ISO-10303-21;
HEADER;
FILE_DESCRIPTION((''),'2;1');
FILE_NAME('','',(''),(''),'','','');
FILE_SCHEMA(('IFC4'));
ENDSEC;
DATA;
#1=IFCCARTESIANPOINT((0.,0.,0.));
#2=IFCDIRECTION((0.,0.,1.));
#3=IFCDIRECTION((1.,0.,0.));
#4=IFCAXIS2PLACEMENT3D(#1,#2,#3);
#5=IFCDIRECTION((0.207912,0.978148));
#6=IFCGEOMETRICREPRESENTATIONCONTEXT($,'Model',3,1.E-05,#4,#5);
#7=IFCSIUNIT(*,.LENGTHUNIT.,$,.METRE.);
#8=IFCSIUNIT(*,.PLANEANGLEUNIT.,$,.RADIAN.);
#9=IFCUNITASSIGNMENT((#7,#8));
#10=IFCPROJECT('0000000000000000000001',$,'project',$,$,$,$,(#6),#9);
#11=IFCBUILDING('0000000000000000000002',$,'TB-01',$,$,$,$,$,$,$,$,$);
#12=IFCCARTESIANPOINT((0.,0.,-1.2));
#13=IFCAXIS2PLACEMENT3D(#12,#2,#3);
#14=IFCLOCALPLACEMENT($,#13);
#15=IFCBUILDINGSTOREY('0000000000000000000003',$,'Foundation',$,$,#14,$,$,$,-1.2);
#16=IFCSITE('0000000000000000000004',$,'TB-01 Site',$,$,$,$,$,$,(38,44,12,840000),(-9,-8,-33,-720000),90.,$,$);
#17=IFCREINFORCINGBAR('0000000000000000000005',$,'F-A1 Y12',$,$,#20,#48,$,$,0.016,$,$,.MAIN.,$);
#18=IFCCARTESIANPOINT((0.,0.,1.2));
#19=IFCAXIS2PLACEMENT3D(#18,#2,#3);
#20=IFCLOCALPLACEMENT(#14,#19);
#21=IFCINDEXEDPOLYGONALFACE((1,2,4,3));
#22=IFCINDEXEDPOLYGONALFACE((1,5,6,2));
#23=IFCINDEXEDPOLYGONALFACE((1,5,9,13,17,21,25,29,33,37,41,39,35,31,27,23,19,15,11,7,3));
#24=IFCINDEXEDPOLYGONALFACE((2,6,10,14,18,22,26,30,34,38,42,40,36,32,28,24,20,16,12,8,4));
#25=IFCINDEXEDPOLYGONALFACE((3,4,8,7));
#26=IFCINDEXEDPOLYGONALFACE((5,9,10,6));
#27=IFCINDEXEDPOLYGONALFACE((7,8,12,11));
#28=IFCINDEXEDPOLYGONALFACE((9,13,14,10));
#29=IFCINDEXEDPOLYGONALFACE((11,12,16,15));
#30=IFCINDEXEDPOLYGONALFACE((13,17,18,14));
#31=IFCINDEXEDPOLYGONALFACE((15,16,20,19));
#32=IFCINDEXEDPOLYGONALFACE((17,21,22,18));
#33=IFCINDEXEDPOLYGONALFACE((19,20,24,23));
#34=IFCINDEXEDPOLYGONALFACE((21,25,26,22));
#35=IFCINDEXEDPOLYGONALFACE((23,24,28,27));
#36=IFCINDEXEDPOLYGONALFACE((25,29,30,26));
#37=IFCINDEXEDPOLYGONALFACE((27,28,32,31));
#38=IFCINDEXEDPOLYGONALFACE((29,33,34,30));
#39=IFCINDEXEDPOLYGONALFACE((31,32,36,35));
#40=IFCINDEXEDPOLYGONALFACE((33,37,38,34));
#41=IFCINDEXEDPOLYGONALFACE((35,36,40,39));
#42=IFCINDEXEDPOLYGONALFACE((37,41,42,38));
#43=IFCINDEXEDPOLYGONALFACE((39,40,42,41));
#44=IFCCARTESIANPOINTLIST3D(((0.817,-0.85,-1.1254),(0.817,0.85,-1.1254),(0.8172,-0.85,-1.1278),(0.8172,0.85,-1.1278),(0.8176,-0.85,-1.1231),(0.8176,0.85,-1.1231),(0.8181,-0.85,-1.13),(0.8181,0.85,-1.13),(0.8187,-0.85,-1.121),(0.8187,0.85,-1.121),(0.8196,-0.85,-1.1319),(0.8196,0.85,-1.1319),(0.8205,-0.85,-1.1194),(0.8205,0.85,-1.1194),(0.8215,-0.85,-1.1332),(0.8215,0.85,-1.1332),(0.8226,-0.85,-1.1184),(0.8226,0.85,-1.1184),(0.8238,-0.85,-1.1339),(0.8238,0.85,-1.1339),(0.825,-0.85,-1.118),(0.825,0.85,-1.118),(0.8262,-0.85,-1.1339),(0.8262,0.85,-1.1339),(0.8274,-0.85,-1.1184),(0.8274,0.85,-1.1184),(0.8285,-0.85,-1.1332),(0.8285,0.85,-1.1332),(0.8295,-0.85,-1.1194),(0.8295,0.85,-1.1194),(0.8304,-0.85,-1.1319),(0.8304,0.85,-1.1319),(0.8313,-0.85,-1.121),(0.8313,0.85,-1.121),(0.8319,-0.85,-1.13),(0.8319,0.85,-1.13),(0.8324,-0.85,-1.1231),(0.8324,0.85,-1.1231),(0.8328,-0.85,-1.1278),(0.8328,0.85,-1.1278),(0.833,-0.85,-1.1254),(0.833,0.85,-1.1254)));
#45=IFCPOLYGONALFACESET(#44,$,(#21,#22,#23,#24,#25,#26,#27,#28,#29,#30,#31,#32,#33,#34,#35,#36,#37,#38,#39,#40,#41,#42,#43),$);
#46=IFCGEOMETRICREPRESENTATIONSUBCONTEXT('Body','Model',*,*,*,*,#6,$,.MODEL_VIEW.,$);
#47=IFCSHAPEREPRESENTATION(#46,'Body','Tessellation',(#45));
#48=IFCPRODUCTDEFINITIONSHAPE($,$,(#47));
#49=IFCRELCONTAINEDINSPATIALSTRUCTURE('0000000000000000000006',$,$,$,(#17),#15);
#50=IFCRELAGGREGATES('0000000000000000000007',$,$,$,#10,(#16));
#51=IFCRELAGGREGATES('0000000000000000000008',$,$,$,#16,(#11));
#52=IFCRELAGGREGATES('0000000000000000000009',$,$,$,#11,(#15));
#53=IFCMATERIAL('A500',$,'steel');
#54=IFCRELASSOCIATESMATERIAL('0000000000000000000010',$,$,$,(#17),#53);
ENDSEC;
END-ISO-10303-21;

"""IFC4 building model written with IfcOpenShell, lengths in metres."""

from ifc_helpers import new_model, entity, si_unit, direction, frame, origin_with_axes, place, context, subcontext, project, spatial, material, element, save


model = new_model("IFC4")

# Units and contexts
model_context = context("Model", 3, precision=1e-05, world=origin_with_axes(), true_north=direction((0.207912, 0.978148)))
body_context = subcontext(model_context, "Body", "Model", "MODEL_VIEW")
ifc_project = project(units=[si_unit("LENGTHUNIT", "METRE"), si_unit("PLANEANGLEUNIT", "RADIAN")], contexts=[model_context])

# Site, building, storey
site = spatial("IfcSite", under=ifc_project, Name="TB-01 Site", RefLatitude=(38, 44, 12, 840000), RefLongitude=(-9, -8, -33, -720000), RefElevation=90.0)
building = spatial("IfcBuilding", under=site, Name="TB-01")
storey_placement = place(None, frame((0.0, 0.0, -1.2), z_axis=(0.0, 0.0, 1.0), x_axis=(1.0, 0.0, 0.0)))
storey = spatial("IfcBuildingStorey", under=building, at=storey_placement, Name="Foundation", Elevation=-1.2)

# Reinforcing bar
ifc_material_1 = material(Name="A500", Category="steel")
reinforcing_bar_1_placement = place(storey_placement, frame((0.0, 0.0, 1.2), z_axis=(0.0, 0.0, 1.0), x_axis=(1.0, 0.0, 0.0)))
element("IfcReinforcingBar", 1, at=reinforcing_bar_1_placement, inside=storey, material=ifc_material_1, Name="F-A1 Y12", NominalDiameter=0.016, PredefinedType="MAIN", context=body_context, shape_type="AdvancedSweptSolid", body=[
    entity("IfcSweptDiskSolid", entity("IfcPolyline", [entity("IfcCartesianPoint", [0.825, -0.85, -1.126]), entity("IfcCartesianPoint", [0.825, 0.85, -1.126])]), 0.008),
])

save(model, "model.ifc")
